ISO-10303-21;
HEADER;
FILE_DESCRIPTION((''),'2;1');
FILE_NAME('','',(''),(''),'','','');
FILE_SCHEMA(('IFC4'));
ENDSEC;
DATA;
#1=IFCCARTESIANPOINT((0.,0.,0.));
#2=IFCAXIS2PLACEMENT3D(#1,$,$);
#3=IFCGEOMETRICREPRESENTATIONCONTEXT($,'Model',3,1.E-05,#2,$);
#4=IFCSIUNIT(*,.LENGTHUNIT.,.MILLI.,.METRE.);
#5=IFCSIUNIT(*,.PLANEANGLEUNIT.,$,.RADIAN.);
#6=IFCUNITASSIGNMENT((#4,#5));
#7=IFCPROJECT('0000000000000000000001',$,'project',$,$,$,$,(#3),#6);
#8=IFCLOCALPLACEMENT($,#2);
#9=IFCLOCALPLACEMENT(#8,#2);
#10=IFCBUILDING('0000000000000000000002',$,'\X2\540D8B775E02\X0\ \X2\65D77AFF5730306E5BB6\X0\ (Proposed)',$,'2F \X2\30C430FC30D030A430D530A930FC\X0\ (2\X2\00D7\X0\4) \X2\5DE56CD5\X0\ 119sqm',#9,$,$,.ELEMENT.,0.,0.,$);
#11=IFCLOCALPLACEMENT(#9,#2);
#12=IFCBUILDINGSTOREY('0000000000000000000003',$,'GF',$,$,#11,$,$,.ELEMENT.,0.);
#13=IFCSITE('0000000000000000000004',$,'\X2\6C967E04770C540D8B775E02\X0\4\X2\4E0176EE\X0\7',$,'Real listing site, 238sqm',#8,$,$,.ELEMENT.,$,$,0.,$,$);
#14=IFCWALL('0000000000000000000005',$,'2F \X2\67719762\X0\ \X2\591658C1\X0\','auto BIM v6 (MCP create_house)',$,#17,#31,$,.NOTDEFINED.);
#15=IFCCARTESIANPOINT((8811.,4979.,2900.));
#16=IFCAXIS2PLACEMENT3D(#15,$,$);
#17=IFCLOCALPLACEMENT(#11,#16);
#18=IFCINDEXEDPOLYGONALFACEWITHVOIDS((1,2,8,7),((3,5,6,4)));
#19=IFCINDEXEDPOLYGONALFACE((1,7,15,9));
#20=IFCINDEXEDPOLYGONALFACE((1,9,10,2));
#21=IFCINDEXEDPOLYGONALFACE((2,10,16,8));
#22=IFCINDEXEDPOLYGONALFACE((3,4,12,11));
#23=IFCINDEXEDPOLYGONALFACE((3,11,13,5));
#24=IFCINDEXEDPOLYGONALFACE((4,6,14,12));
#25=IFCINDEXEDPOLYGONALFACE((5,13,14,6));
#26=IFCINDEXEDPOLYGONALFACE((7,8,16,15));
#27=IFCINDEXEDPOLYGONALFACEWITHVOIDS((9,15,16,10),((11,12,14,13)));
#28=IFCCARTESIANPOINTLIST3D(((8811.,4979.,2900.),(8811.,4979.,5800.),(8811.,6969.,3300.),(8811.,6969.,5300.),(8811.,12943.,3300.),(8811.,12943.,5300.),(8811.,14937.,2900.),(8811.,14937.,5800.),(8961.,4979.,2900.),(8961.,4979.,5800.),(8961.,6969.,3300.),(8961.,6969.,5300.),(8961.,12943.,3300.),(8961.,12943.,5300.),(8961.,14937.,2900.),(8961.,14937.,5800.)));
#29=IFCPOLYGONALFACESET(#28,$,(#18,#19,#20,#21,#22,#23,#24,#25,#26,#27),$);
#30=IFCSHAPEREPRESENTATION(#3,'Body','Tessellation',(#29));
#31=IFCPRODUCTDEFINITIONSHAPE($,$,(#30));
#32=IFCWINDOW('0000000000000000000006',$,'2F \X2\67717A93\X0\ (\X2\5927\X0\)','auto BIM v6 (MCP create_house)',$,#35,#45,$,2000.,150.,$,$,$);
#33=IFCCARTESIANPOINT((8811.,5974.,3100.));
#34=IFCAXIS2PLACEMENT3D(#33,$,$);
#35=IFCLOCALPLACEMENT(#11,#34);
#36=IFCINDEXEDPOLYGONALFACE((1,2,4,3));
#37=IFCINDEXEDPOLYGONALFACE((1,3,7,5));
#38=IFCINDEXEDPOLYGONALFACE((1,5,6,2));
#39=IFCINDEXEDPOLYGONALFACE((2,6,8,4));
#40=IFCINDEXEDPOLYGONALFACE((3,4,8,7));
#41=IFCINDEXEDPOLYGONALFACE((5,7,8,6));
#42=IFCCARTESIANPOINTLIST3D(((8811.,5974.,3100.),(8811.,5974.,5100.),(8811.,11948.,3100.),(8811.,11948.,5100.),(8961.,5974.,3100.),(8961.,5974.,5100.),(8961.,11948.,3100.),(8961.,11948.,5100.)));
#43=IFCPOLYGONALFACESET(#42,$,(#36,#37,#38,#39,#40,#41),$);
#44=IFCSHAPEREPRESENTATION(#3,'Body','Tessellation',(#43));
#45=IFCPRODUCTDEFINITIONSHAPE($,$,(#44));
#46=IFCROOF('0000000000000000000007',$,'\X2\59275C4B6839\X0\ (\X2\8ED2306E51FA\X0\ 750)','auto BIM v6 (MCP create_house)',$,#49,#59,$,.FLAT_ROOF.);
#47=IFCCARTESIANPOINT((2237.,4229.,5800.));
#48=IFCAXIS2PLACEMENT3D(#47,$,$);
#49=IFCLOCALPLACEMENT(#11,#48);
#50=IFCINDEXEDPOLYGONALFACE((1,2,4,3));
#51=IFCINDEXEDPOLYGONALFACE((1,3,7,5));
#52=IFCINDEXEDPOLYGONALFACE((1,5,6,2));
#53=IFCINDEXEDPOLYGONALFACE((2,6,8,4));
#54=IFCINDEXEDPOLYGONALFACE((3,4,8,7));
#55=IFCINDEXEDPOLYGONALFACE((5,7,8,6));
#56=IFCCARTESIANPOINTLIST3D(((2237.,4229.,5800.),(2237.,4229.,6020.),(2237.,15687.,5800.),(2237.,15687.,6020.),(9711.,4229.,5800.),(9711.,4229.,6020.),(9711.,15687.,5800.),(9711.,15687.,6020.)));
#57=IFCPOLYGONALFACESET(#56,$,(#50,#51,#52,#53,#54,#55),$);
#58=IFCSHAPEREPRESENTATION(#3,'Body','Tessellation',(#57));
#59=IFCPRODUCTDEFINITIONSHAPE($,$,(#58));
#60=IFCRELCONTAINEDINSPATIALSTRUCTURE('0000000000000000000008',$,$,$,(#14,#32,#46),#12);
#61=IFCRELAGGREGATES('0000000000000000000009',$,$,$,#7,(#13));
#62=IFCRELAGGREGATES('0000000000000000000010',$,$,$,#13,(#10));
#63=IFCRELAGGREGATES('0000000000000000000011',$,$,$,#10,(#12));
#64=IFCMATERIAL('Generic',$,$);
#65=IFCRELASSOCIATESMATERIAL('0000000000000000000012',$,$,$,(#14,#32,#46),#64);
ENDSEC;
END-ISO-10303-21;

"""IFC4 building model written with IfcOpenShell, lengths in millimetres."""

from ifc_helpers import new_model, si_unit, frame, frame_2d, origin, place, context, project, spatial, rectangle, extrude, material, element, fill, save


model = new_model("IFC4")

# Units and contexts
model_context = context("Model", 3, precision=1e-05, world=origin())
ifc_project = project(units=[si_unit("LENGTHUNIT", "METRE", prefix="MILLI"), si_unit("PLANEANGLEUNIT", "RADIAN")], contexts=[model_context])

# Site, building, storey
site_placement = place(None, origin())
site = spatial("IfcSite", under=ifc_project, at=site_placement, Name="沖縄県名護市4丁目7", ObjectType="Real listing site, 238sqm", CompositionType="ELEMENT", RefElevation=0.0)
building_placement = place(site_placement, origin())
building = spatial("IfcBuilding", under=site, at=building_placement, Name="名護市 旗竿地の家 (Proposed)", ObjectType="2F ツーバイフォー (2×4) 工法 119sqm", CompositionType="ELEMENT", ElevationOfRefHeight=0.0, ElevationOfTerrain=0.0)
storey_placement = place(building_placement, origin())
storey = spatial("IfcBuildingStorey", under=building, at=storey_placement, Name="GF", CompositionType="ELEMENT", Elevation=0.0)

# Shared definitions
ifc_material = material(Name="Generic")

# Wall, opening, window
wall_1_placement = place(storey_placement, frame((8811.0, 4979.0, 2900.0)))
wall_1 = element("IfcWall", 1, at=wall_1_placement, inside=storey, material=ifc_material, Name="2F 東面 外壁", Description="auto BIM v6 (MCP create_house)", PredefinedType="NOTDEFINED", context=model_context, shape_type="SweptSolid", body=[
    extrude(rectangle(XDim=150.0, YDim=9958.0, at=frame_2d((75.0, 4979.0))), frame((8811.0, 4979.0, 2900.0)), (0.0, 0.0, 1.0), 2900.0),
])
opening_1_placement = place(storey_placement, frame((8811.0, 5974.0, 3100.0)))
opening_1 = element("IfcOpeningElement", 2, at=opening_1_placement, cuts=wall_1, PredefinedType="NOTDEFINED", context=model_context, shape_type="SweptSolid", body=[
    extrude(rectangle(XDim=150.0, YDim=5974.0, at=frame_2d((75.0, 2987.0))), frame((8811.0, 5974.0, 3100.0)), (0.0, 0.0, 1.0), 2000.0),
])
window_1_placement = place(storey_placement, frame((8811.0, 5974.0, 3100.0)))
window_1 = element("IfcWindow", 3, at=window_1_placement, inside=storey, material=ifc_material, Name="2F 東窓 (大)", Description="auto BIM v6 (MCP create_house)", OverallHeight=2000.0, OverallWidth=150.0, context=model_context, shape_type="SweptSolid", body=[
    extrude(rectangle(XDim=150.0, YDim=5974.0, at=frame_2d((75.0, 2987.0))), frame((8811.0, 5974.0, 3100.0)), (0.0, 0.0, 1.0), 2000.0),
])
fill(opening_1, window_1)

# Roof
roof_placement = place(storey_placement, frame((2237.0, 4229.0, 5800.0)))
element("IfcRoof", 4, at=roof_placement, inside=storey, material=ifc_material, Name="大屋根 (軒の出 750)", Description="auto BIM v6 (MCP create_house)", PredefinedType="FLAT_ROOF", context=model_context, shape_type="SweptSolid", body=[
    extrude(rectangle(XDim=7474.0, YDim=11458.0, at=frame_2d((3737.0, 5729.0))), frame((2237.0, 4229.0, 5800.0)), (0.0, 0.0, 1.0), 220.0),
])

save(model, "model.ifc")
